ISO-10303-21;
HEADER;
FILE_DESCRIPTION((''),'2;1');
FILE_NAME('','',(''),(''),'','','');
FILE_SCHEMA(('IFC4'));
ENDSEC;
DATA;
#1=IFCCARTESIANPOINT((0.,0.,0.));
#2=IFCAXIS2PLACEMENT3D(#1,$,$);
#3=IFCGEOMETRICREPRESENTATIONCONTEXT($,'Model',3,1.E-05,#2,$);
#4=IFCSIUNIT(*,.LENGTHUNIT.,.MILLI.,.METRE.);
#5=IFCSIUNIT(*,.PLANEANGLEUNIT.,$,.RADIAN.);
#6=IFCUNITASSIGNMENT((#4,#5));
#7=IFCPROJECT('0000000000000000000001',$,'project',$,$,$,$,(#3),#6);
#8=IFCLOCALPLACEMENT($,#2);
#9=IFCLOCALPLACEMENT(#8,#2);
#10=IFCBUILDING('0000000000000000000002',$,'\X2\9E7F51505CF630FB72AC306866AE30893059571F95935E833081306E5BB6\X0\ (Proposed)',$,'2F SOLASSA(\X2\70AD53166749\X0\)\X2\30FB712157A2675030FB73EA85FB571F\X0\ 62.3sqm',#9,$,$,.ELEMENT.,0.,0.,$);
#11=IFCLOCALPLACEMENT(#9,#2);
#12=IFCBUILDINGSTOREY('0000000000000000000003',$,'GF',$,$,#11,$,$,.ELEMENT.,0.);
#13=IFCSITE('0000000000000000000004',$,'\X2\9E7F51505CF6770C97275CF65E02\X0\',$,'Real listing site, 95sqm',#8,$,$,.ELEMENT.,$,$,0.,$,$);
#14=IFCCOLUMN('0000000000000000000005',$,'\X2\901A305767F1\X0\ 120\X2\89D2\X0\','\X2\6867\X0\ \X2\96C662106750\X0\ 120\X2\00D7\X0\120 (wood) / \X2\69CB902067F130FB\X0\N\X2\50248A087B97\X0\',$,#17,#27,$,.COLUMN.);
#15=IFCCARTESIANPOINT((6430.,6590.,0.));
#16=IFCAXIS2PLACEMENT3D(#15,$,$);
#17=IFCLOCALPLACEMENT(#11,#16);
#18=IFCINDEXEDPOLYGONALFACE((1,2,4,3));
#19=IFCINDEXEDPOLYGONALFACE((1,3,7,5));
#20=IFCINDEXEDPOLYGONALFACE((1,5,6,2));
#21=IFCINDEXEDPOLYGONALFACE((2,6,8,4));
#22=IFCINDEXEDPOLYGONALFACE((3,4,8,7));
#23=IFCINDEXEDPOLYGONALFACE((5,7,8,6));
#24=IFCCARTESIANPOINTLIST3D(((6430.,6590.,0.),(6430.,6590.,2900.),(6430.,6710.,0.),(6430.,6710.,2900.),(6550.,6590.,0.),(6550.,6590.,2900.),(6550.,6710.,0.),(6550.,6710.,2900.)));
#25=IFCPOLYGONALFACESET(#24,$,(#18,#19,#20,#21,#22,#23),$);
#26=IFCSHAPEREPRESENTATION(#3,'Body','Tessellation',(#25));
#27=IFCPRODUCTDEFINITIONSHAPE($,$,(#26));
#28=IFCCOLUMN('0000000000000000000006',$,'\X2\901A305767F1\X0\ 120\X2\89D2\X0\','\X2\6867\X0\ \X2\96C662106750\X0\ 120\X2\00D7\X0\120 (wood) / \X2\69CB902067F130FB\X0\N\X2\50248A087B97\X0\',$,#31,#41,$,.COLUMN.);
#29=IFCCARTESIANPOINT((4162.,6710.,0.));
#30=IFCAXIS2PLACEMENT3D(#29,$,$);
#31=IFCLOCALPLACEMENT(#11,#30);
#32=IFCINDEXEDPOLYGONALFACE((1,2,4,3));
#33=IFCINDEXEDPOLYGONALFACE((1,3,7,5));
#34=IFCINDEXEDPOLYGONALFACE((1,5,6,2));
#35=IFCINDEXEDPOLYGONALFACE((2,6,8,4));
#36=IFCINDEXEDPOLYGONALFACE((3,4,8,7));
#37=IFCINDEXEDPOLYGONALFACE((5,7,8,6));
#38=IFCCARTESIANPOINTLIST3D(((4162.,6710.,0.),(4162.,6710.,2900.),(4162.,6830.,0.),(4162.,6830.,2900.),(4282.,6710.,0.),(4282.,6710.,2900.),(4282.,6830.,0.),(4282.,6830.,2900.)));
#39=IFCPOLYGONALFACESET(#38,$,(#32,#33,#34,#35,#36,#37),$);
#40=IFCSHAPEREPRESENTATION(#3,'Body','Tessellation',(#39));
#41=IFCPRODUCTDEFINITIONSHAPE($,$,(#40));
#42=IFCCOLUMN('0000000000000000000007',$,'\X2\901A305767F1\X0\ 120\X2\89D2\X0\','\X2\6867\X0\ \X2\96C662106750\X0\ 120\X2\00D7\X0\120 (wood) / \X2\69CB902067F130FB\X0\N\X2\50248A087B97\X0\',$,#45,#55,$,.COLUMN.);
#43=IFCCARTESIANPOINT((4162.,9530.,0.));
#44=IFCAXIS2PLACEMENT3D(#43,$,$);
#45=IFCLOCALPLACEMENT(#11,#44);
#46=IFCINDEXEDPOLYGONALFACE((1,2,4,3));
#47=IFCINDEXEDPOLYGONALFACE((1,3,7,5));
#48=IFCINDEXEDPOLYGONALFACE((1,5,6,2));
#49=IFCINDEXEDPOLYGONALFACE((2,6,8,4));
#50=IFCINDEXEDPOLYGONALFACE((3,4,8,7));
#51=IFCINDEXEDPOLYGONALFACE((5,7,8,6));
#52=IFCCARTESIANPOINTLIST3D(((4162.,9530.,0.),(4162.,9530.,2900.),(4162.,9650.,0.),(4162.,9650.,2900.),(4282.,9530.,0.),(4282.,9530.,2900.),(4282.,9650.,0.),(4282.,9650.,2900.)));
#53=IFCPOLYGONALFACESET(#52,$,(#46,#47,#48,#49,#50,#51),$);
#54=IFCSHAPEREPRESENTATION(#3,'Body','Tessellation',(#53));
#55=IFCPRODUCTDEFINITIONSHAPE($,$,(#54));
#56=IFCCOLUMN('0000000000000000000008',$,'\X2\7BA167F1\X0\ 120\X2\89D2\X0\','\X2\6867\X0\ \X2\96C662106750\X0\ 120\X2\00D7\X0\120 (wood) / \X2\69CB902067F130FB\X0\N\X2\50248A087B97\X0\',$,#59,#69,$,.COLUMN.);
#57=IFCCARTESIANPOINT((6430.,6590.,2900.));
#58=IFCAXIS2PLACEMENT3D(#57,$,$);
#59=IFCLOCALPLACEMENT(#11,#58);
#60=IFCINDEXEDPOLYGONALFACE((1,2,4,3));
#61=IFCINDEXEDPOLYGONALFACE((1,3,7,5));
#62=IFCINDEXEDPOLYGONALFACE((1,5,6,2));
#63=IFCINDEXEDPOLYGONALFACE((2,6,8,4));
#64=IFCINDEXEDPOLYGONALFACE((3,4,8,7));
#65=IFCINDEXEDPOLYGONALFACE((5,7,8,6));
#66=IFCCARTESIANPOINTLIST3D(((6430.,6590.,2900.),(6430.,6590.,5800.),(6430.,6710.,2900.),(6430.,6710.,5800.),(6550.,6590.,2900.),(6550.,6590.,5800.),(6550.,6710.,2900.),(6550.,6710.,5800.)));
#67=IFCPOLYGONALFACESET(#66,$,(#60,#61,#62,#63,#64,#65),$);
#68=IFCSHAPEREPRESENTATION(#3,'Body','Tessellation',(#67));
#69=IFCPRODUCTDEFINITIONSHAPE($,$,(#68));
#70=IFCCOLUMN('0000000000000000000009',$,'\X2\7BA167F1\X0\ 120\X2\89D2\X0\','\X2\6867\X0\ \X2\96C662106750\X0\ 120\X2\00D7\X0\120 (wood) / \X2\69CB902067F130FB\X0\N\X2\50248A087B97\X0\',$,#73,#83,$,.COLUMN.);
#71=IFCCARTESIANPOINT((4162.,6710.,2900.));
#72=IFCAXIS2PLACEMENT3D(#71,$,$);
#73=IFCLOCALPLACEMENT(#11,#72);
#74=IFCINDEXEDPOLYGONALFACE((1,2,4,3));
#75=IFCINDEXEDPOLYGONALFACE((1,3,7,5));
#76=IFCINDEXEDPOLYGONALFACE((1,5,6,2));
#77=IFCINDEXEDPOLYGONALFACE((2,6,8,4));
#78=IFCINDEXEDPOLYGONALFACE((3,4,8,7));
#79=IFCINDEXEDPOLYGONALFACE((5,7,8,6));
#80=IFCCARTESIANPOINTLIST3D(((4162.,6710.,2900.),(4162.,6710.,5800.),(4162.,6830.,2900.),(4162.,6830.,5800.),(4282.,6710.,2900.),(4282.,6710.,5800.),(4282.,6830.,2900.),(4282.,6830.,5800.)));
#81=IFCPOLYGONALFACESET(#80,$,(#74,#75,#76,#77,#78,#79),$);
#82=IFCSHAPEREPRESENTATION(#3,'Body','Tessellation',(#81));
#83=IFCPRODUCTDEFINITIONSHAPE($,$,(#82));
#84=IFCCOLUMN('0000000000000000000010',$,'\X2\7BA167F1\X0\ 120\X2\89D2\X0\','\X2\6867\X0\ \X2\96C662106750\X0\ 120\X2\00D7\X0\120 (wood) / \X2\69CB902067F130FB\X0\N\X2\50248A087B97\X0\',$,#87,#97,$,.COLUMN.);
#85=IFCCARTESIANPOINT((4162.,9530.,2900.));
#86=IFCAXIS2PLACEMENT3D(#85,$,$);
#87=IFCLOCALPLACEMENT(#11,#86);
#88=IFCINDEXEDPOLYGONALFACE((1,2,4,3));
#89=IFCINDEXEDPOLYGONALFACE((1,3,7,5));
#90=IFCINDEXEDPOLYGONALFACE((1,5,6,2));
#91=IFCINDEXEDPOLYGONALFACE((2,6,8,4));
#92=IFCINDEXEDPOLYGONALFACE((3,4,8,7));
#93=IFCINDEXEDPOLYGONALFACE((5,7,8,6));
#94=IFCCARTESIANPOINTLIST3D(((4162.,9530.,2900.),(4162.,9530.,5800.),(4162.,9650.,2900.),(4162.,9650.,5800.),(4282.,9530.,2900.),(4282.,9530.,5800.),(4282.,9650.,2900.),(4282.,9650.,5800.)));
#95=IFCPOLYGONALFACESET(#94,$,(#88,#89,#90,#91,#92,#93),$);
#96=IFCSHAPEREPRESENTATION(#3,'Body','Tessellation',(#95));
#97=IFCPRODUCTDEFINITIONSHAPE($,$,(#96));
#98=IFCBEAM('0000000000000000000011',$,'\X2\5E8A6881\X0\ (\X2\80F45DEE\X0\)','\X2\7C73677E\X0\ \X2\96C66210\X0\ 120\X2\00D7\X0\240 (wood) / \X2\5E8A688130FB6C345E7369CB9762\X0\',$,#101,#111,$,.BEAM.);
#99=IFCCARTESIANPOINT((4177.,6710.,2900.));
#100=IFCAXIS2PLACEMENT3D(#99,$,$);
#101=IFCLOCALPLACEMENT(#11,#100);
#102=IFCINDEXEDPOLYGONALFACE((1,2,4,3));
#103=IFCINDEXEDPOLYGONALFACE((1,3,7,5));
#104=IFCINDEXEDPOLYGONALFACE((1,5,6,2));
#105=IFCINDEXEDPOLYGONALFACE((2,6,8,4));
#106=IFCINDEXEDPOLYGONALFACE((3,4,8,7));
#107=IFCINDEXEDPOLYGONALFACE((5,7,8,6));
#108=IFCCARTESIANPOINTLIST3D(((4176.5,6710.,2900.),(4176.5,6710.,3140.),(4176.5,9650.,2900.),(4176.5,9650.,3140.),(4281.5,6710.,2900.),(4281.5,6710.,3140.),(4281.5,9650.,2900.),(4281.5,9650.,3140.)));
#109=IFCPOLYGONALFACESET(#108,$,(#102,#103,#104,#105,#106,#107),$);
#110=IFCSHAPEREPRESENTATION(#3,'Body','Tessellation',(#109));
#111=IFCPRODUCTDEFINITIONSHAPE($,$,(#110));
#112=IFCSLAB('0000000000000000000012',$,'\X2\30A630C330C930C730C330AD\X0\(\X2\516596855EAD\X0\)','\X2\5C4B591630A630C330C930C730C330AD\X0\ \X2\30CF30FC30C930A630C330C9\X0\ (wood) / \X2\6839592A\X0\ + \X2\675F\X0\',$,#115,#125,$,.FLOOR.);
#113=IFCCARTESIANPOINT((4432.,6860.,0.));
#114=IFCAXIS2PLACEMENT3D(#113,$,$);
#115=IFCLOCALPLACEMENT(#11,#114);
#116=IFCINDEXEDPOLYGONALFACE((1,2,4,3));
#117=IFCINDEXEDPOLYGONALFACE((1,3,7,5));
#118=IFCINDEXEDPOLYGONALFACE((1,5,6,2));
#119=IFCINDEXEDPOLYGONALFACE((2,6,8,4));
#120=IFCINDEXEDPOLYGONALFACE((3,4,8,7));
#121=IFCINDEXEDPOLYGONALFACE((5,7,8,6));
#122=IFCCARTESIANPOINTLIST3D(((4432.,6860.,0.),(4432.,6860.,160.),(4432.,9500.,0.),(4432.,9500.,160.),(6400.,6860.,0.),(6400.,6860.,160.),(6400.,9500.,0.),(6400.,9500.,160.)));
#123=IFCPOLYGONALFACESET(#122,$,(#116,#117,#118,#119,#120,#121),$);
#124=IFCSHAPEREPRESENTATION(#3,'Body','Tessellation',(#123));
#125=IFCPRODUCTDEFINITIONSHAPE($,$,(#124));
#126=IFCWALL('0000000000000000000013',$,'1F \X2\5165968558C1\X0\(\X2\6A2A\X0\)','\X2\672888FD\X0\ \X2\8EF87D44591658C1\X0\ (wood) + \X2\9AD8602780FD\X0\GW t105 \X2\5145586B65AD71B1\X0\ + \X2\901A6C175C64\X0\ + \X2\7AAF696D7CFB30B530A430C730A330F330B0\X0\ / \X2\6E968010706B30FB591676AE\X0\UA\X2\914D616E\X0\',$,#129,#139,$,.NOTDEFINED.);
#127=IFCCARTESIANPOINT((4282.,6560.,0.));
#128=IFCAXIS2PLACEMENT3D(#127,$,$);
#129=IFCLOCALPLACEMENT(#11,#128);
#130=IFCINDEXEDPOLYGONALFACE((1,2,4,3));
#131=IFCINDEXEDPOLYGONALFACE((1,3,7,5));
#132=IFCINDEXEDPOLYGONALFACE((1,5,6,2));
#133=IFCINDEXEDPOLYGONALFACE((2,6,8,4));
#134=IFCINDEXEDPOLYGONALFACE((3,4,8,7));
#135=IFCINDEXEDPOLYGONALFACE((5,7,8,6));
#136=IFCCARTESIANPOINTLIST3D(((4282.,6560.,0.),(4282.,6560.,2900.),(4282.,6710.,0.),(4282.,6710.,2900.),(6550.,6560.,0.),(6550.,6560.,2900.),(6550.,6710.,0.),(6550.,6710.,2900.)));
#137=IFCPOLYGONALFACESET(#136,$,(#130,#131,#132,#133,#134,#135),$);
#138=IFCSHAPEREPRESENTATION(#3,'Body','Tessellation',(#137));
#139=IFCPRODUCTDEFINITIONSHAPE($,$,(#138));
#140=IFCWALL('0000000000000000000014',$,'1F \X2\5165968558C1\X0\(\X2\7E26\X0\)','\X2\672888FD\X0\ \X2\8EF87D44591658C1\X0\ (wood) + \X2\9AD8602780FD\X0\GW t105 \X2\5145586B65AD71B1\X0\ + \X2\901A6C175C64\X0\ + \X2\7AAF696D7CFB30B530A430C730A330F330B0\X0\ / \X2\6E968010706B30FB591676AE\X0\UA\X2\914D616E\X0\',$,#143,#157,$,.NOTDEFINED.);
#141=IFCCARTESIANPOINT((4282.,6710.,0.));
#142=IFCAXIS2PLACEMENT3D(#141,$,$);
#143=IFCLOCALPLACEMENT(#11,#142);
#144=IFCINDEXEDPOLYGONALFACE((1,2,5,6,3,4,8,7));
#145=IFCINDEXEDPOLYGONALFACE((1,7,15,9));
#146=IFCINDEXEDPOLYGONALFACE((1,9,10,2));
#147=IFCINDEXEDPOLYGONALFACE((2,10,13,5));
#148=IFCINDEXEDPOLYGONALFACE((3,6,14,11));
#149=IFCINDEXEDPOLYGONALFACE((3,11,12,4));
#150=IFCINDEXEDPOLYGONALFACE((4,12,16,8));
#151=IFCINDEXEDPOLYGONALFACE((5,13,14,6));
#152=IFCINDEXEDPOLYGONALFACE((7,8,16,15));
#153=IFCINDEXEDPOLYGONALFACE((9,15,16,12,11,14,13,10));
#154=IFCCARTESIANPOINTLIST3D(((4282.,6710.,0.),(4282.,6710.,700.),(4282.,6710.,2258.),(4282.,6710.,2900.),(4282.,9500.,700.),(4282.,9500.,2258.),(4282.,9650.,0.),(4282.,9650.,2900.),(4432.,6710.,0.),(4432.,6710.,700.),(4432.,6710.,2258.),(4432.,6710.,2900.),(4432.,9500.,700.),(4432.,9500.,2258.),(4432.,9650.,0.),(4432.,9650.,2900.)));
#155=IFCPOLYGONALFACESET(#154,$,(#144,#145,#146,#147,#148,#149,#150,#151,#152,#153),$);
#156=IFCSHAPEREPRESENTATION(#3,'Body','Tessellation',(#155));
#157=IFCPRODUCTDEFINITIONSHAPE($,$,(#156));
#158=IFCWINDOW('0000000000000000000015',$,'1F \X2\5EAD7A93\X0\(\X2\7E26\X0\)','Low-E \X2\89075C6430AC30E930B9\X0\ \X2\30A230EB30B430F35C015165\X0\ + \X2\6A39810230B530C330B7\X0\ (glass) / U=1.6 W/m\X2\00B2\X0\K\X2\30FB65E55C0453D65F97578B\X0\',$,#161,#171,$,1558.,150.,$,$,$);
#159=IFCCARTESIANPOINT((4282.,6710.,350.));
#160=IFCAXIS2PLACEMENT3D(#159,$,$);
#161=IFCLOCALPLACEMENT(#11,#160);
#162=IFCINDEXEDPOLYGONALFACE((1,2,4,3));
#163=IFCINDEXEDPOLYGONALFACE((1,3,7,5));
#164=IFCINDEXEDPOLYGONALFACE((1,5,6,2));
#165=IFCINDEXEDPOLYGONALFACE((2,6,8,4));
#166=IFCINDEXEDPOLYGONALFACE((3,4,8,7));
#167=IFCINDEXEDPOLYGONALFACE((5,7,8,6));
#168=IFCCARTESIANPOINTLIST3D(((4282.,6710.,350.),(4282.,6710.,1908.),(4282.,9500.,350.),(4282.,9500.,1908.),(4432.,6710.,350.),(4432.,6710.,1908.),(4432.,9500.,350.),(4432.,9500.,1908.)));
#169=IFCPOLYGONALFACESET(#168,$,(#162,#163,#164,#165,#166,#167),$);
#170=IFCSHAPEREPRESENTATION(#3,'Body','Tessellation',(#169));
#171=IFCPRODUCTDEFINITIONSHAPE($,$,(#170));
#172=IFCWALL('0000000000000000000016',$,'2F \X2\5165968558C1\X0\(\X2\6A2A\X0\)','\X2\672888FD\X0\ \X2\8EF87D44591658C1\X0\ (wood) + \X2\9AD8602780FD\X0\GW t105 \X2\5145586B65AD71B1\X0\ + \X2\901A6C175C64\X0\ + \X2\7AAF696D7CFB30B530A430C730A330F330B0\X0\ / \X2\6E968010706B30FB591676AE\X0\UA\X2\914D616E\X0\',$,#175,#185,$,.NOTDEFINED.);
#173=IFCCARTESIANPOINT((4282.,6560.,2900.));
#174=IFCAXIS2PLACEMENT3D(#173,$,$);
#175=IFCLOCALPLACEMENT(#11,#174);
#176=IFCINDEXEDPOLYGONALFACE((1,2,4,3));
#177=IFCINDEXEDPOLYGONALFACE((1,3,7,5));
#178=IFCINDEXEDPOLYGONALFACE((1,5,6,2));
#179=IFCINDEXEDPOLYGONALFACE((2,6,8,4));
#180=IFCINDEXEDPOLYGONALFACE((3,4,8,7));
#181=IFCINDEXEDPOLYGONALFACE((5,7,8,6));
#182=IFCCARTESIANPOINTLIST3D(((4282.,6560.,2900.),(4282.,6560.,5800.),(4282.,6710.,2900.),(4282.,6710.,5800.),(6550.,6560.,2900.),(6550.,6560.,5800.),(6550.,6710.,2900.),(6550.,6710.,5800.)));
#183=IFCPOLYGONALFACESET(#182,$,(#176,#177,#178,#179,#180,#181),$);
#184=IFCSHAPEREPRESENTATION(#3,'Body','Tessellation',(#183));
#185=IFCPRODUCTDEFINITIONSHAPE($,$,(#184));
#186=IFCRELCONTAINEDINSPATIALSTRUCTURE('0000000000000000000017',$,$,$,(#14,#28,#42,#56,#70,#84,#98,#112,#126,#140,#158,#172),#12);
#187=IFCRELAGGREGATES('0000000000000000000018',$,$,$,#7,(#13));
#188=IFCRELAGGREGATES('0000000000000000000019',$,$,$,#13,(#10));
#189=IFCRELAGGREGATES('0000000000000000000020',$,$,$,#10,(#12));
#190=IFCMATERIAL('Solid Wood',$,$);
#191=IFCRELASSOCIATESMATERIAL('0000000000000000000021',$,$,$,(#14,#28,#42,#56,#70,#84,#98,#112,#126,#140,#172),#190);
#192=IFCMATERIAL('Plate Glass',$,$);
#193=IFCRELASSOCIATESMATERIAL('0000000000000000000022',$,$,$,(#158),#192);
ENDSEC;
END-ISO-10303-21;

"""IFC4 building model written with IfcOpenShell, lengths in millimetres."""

from ifc_helpers import new_model, si_unit, frame, frame_2d, origin, place, context, project, spatial, rectangle, extrude, material, element, fill, save


model = new_model("IFC4")

# Units and contexts
model_context = context("Model", 3, precision=1e-05, world=origin())
ifc_project = project(units=[si_unit("LENGTHUNIT", "METRE", prefix="MILLI"), si_unit("PLANEANGLEUNIT", "RADIAN")], contexts=[model_context])

# Site, building, storey
site_placement = place(None, origin())
site = spatial("IfcSite", under=ifc_project, at=site_placement, Name="鹿児島県霧島市", ObjectType="Real listing site, 95sqm", CompositionType="ELEMENT", RefElevation=0.0)
building_placement = place(site_placement, origin())
building = spatial("IfcBuilding", under=site, at=building_placement, Name="鹿児島・犬と暮らす土間広めの家 (Proposed)", ObjectType="2F SOLASSA(炭化杉)・無垢材・珪藻土 62.3sqm", CompositionType="ELEMENT", ElevationOfRefHeight=0.0, ElevationOfTerrain=0.0)
storey_placement = place(building_placement, origin())
storey = spatial("IfcBuildingStorey", under=building, at=storey_placement, Name="GF", CompositionType="ELEMENT", Elevation=0.0)

# Columns
ifc_material_1 = material(Name="Solid Wood")
column_1_placement = place(storey_placement, frame((6430.0, 6590.0, 0.0)))
element("IfcColumn", 1, at=column_1_placement, inside=storey, material=ifc_material_1, Name="通し柱 120角", Description="桧 集成材 120×120 (wood) / 構造柱・N値計算", PredefinedType="COLUMN", context=model_context, shape_type="SweptSolid", body=[
    extrude(rectangle(XDim=120.0, YDim=120.0, at=frame_2d((60.0, 60.0))), frame((6430.0, 6590.0, 0.0)), (0.0, 0.0, 1.0), 2900.0),
])
column_2_placement = place(storey_placement, frame((4162.0, 6710.0, 0.0)))
element("IfcColumn", 2, at=column_2_placement, inside=storey, material=ifc_material_1, Name="通し柱 120角", Description="桧 集成材 120×120 (wood) / 構造柱・N値計算", PredefinedType="COLUMN", context=model_context, shape_type="SweptSolid", body=[
    extrude(rectangle(XDim=120.0, YDim=120.0, at=frame_2d((60.0, 60.0))), frame((4162.0, 6710.0, 0.0)), (0.0, 0.0, 1.0), 2900.0),
])
column_3_placement = place(storey_placement, frame((4162.0, 9530.0, 0.0)))
element("IfcColumn", 3, at=column_3_placement, inside=storey, material=ifc_material_1, Name="通し柱 120角", Description="桧 集成材 120×120 (wood) / 構造柱・N値計算", PredefinedType="COLUMN", context=model_context, shape_type="SweptSolid", body=[
    extrude(rectangle(XDim=120.0, YDim=120.0, at=frame_2d((60.0, 60.0))), frame((4162.0, 9530.0, 0.0)), (0.0, 0.0, 1.0), 2900.0),
])
column_4_placement = place(storey_placement, frame((6430.0, 6590.0, 2900.0)))
element("IfcColumn", 4, at=column_4_placement, inside=storey, material=ifc_material_1, Name="管柱 120角", Description="桧 集成材 120×120 (wood) / 構造柱・N値計算", PredefinedType="COLUMN", context=model_context, shape_type="SweptSolid", body=[
    extrude(rectangle(XDim=120.0, YDim=120.0, at=frame_2d((60.0, 60.0))), frame((6430.0, 6590.0, 2900.0)), (0.0, 0.0, 1.0), 2900.0),
])
column_5_placement = place(storey_placement, frame((4162.0, 6710.0, 2900.0)))
element("IfcColumn", 5, at=column_5_placement, inside=storey, material=ifc_material_1, Name="管柱 120角", Description="桧 集成材 120×120 (wood) / 構造柱・N値計算", PredefinedType="COLUMN", context=model_context, shape_type="SweptSolid", body=[
    extrude(rectangle(XDim=120.0, YDim=120.0, at=frame_2d((60.0, 60.0))), frame((4162.0, 6710.0, 2900.0)), (0.0, 0.0, 1.0), 2900.0),
])
column_6_placement = place(storey_placement, frame((4162.0, 9530.0, 2900.0)))
element("IfcColumn", 6, at=column_6_placement, inside=storey, material=ifc_material_1, Name="管柱 120角", Description="桧 集成材 120×120 (wood) / 構造柱・N値計算", PredefinedType="COLUMN", context=model_context, shape_type="SweptSolid", body=[
    extrude(rectangle(XDim=120.0, YDim=120.0, at=frame_2d((60.0, 60.0))), frame((4162.0, 9530.0, 2900.0)), (0.0, 0.0, 1.0), 2900.0),
])

# Beam
beam_1_placement = place(storey_placement, frame((4177.0, 6710.0, 2900.0)))
element("IfcBeam", 7, at=beam_1_placement, inside=storey, material=ifc_material_1, Name="床梁 (胴差)", Description="米松 集成 120×240 (wood) / 床梁・水平構面", PredefinedType="BEAM", context=model_context, shape_type="SweptSolid", body=[
    extrude(rectangle(XDim=105.0, YDim=2940.0, at=frame_2d((52.0, 1470.0))), frame((4177.0, 6710.0, 2900.0)), (0.0, 0.0, 1.0), 240.0),
])

# Slab
slab_placement = place(storey_placement, frame((4432.0, 6860.0, 0.0)))
element("IfcSlab", 8, at=slab_placement, inside=storey, material=ifc_material_1, Name="ウッドデッキ(入隅庭)", Description="屋外ウッドデッキ ハードウッド (wood) / 根太 + 束", PredefinedType="FLOOR", context=model_context, shape_type="SweptSolid", body=[
    extrude(rectangle(XDim=1968.0, YDim=2640.0, at=frame_2d((984.0, 1320.0))), frame((4432.0, 6860.0, 0.0)), (0.0, 0.0, 1.0), 160.0),
])

# Wall
wall_1_placement = place(storey_placement, frame((4282.0, 6560.0, 0.0)))
element("IfcWall", 9, at=wall_1_placement, inside=storey, material=ifc_material_1, Name="1F 入隅壁(横)", Description="木製 軸組外壁 (wood) + 高性能GW t105 充填断熱 + 通気層 + 窯業系サイディング / 準耐火・外皮UA配慮", PredefinedType="NOTDEFINED", context=model_context, shape_type="SweptSolid", body=[
    extrude(rectangle(XDim=2268.0, YDim=150.0, at=frame_2d((1134.0, 75.0))), frame((4282.0, 6560.0, 0.0)), (0.0, 0.0, 1.0), 2900.0),
])

# Wall, opening, window
wall_2_placement = place(storey_placement, frame((4282.0, 6710.0, 0.0)))
wall_2 = element("IfcWall", 10, at=wall_2_placement, inside=storey, material=ifc_material_1, Name="1F 入隅壁(縦)", Description="木製 軸組外壁 (wood) + 高性能GW t105 充填断熱 + 通気層 + 窯業系サイディング / 準耐火・外皮UA配慮", PredefinedType="NOTDEFINED", context=model_context, shape_type="SweptSolid", body=[
    extrude(rectangle(XDim=150.0, YDim=2940.0, at=frame_2d((75.0, 1470.0))), frame((4282.0, 6710.0, 0.0)), (0.0, 0.0, 1.0), 2900.0),
])
opening_1_placement = place(storey_placement, frame((4282.0, 6710.0, 350.0)))
opening_1 = element("IfcOpeningElement", 11, at=opening_1_placement, cuts=wall_2, PredefinedType="NOTDEFINED", context=model_context, shape_type="SweptSolid", body=[
    extrude(rectangle(XDim=150.0, YDim=2790.0, at=frame_2d((75.0, 1395.0))), frame((4282.0, 6710.0, 350.0)), (0.0, 0.0, 1.0), 1558.0),
])
ifc_material_2 = material(Name="Plate Glass")
window_1_placement = place(storey_placement, frame((4282.0, 6710.0, 350.0)))
window_1 = element("IfcWindow", 12, at=window_1_placement, inside=storey, material=ifc_material_2, Name="1F 庭窓(縦)", Description="Low-E 複層ガラス アルゴン封入 + 樹脂サッシ (glass) / U=1.6 W/m²K・日射取得型", OverallHeight=1558.0, OverallWidth=150.0, context=model_context, shape_type="SweptSolid", body=[
    extrude(rectangle(XDim=150.0, YDim=2790.0, at=frame_2d((75.0, 1395.0))), frame((4282.0, 6710.0, 350.0)), (0.0, 0.0, 1.0), 1558.0),
])
fill(opening_1, window_1)

# Wall
wall_3_placement = place(storey_placement, frame((4282.0, 6560.0, 2900.0)))
element("IfcWall", 13, at=wall_3_placement, inside=storey, material=ifc_material_1, Name="2F 入隅壁(横)", Description="木製 軸組外壁 (wood) + 高性能GW t105 充填断熱 + 通気層 + 窯業系サイディング / 準耐火・外皮UA配慮", PredefinedType="NOTDEFINED", context=model_context, shape_type="SweptSolid", body=[
    extrude(rectangle(XDim=2268.0, YDim=150.0, at=frame_2d((1134.0, 75.0))), frame((4282.0, 6560.0, 2900.0)), (0.0, 0.0, 1.0), 2900.0),
])

save(model, "model.ifc")
